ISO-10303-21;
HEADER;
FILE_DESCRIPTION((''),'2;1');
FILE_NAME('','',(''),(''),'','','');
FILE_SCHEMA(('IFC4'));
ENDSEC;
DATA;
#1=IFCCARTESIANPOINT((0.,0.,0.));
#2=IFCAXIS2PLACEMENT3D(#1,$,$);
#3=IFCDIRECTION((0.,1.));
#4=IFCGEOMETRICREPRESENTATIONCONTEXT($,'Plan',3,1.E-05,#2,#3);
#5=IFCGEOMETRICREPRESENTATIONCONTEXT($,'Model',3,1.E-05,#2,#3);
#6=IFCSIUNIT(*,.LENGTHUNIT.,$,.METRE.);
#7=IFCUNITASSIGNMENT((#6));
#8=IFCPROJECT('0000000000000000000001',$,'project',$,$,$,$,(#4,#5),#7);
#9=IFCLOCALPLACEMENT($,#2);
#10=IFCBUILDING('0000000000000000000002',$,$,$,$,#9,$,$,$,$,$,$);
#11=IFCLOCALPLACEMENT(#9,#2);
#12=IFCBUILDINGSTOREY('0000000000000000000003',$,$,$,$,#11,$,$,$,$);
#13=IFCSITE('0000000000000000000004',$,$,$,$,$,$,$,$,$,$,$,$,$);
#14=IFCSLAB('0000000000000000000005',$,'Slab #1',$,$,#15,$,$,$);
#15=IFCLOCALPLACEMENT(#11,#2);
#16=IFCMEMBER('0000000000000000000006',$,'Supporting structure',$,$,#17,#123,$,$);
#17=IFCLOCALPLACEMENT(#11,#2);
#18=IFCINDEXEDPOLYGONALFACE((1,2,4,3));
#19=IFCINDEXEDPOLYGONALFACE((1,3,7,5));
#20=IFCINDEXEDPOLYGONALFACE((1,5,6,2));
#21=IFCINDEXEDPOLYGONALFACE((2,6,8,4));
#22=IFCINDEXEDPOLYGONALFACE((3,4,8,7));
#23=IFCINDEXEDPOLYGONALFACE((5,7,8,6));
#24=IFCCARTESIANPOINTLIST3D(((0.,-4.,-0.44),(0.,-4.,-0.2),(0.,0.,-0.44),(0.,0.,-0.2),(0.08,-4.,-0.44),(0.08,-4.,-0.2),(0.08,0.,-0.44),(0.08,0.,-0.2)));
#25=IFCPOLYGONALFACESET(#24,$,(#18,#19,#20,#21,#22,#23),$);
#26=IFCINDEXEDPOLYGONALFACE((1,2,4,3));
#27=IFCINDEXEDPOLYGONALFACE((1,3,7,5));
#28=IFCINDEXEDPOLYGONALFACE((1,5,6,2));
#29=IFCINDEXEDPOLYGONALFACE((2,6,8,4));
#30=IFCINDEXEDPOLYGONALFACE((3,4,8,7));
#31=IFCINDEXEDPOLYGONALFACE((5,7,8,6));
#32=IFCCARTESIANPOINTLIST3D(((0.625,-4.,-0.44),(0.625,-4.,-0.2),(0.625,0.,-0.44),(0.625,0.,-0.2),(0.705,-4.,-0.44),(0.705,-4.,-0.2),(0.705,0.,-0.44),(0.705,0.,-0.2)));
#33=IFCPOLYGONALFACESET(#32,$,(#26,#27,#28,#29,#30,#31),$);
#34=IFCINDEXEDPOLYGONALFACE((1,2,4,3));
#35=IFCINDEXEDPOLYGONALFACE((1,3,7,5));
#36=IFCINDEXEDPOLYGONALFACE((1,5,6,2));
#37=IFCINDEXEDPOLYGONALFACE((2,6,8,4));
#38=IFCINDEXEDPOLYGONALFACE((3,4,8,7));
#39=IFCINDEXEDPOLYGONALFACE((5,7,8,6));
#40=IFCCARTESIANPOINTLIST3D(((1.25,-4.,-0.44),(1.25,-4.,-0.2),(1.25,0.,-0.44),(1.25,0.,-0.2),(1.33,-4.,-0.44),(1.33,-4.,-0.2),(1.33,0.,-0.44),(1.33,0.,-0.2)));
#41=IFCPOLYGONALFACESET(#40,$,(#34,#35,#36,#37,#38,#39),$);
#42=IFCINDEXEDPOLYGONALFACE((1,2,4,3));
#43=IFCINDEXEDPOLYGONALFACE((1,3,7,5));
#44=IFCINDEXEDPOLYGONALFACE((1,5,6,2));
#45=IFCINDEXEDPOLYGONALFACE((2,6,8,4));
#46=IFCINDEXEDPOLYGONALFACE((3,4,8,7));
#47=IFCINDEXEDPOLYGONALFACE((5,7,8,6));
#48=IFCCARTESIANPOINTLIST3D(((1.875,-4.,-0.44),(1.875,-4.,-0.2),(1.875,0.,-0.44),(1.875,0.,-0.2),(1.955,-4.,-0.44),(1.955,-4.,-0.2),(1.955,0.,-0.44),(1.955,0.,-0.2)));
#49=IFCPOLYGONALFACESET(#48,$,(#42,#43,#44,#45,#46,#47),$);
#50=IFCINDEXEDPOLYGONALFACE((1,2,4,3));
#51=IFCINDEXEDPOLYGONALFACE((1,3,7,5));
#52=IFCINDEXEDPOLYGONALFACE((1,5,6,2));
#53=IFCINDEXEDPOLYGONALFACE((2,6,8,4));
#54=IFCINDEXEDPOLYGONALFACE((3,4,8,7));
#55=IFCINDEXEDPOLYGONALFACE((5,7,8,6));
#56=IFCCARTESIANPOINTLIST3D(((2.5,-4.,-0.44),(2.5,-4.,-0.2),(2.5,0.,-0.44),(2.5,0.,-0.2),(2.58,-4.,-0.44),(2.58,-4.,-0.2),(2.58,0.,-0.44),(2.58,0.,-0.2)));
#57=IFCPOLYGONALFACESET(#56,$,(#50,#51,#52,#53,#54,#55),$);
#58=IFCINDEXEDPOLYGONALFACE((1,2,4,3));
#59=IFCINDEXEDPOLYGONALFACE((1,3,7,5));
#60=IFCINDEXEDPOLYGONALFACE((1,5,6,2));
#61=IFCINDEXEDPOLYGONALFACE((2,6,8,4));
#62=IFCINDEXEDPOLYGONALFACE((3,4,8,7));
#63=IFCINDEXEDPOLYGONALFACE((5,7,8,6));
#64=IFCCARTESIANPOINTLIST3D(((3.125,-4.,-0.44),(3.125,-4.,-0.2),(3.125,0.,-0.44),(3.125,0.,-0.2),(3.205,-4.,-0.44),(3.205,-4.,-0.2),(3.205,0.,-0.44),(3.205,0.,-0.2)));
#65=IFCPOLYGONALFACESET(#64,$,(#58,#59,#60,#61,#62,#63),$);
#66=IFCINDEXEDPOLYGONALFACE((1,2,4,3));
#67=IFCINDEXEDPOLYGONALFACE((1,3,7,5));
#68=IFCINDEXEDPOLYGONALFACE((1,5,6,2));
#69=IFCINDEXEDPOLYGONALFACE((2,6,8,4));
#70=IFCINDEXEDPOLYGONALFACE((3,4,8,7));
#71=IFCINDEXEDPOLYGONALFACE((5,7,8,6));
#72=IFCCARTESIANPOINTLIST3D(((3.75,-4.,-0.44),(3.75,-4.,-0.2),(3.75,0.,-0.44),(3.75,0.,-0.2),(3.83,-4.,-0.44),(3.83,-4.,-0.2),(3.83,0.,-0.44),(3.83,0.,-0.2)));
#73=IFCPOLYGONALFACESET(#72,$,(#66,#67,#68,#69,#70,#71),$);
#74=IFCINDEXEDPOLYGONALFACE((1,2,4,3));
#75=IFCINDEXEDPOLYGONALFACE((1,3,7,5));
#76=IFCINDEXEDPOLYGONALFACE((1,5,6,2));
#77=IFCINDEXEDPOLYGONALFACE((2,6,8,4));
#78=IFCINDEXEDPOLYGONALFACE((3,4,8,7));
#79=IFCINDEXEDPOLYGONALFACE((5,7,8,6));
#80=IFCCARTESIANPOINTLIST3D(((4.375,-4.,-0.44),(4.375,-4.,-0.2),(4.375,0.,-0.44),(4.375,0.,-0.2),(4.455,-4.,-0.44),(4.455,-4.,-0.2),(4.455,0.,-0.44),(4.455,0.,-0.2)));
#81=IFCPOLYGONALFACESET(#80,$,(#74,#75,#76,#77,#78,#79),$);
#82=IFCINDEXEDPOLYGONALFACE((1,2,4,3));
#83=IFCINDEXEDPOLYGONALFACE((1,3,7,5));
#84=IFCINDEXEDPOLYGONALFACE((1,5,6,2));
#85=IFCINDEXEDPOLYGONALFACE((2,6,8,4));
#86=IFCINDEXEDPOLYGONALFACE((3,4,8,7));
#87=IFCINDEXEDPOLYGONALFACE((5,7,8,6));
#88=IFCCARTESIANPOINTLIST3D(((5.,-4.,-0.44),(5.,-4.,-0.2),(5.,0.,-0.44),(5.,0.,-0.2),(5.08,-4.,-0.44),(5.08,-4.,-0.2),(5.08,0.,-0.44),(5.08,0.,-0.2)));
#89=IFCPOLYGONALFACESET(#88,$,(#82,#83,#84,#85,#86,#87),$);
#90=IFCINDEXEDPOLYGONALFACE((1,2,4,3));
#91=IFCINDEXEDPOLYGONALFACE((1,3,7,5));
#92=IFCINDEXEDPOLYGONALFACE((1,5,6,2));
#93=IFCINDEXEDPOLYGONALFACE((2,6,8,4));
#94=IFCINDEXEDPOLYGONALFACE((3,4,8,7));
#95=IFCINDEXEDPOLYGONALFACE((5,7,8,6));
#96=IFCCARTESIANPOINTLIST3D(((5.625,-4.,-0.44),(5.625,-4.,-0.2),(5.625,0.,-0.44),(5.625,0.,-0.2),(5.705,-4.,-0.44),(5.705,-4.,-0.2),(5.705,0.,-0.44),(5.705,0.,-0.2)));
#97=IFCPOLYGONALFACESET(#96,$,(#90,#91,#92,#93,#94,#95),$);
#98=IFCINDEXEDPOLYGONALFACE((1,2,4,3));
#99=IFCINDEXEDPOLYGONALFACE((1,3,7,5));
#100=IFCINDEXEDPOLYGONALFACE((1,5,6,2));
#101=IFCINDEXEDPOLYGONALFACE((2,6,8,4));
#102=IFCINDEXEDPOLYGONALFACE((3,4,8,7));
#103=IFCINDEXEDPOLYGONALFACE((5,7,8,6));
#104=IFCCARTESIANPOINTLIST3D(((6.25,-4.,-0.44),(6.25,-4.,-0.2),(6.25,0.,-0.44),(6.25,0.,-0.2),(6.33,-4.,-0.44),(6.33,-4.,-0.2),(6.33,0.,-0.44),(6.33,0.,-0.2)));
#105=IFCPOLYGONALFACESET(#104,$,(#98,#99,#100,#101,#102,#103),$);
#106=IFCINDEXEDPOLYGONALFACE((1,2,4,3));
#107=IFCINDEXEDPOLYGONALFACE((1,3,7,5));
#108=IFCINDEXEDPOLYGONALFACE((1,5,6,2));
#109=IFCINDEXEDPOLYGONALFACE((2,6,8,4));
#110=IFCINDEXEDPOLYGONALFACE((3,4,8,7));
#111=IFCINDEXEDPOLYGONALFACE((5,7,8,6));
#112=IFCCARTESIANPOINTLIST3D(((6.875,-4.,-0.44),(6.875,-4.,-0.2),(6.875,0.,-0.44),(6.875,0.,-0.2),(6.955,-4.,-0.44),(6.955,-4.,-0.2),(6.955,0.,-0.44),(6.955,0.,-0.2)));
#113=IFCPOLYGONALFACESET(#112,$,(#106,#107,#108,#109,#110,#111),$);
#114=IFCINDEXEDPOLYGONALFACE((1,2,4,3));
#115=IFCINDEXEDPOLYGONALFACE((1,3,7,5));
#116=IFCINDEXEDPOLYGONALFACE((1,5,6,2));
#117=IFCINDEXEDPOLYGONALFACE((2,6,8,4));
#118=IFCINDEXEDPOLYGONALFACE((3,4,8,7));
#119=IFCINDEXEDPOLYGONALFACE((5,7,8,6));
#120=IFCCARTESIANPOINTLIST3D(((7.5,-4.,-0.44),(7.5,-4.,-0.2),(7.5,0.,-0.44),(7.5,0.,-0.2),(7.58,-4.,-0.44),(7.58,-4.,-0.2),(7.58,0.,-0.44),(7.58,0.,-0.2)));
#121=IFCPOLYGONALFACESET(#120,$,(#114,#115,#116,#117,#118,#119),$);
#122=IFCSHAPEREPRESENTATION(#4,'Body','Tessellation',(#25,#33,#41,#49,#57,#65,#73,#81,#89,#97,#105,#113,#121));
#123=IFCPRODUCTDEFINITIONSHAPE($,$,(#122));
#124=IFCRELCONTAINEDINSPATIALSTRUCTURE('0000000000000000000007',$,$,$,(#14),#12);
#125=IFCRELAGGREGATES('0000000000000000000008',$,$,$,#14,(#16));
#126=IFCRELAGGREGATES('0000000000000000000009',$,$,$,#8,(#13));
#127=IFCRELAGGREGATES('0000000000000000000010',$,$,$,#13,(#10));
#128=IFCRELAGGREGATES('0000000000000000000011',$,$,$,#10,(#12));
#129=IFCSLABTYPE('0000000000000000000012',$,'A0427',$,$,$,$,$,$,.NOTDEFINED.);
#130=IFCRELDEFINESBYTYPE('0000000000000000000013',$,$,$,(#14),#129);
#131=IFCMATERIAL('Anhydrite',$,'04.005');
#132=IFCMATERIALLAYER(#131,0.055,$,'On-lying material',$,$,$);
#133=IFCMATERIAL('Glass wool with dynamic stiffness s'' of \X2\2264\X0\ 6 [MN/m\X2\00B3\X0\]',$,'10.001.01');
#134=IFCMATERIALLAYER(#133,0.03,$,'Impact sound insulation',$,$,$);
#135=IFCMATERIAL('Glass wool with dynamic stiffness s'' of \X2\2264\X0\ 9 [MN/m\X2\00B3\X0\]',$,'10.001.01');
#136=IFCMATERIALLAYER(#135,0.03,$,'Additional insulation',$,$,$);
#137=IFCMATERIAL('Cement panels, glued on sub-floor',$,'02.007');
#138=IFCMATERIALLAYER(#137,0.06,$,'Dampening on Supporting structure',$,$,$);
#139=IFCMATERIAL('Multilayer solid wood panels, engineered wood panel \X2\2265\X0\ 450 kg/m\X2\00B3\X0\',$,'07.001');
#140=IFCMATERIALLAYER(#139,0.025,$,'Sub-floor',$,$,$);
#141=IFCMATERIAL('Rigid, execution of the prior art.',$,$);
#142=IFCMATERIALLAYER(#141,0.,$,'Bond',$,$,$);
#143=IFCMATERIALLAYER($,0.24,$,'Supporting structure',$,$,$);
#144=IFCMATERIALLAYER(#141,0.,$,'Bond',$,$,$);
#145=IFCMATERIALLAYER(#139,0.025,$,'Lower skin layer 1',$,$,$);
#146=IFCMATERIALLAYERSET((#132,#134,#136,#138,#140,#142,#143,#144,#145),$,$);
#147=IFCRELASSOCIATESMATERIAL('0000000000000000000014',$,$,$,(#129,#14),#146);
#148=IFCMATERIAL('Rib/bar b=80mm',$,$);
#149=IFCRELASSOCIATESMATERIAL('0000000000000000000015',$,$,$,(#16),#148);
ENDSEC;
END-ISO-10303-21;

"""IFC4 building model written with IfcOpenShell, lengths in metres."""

from ifc_helpers import new_model, si_unit, direction, frame, frame_2d, origin, place, context, project, spatial, rectangle, extrude, material, layer, layer_set, type_object, element, aggregate, save


model = new_model("IFC4")

# Units and contexts
plan_context = context("Plan", 3, precision=1e-05, world=origin(), true_north=direction((0.0, 1.0)))
model_context = context("Model", 3, precision=1e-05, world=origin(), true_north=direction((0.0, 1.0)))
ifc_project = project(units=[si_unit("LENGTHUNIT", "METRE")], contexts=[plan_context, model_context])

# Site, building, storey
site = spatial("IfcSite", under=ifc_project)
building_placement = place(None, origin())
building = spatial("IfcBuilding", under=site, at=building_placement)
storey_placement = place(building_placement, origin())
storey = spatial("IfcBuildingStorey", under=building, at=storey_placement)

# Slab, member
ifc_material_1 = material(Name="Anhydrite", Category="04.005")
ifc_layer_1 = layer(ifc_material_1, 0.055, Name="On-lying material")
ifc_material_2 = material(Name="Glass wool with dynamic stiffness s' of ≤ 6 [MN/m³]", Category="10.001.01")
ifc_layer_2 = layer(ifc_material_2, 0.03, Name="Impact sound insulation")
ifc_material_3 = material(Name="Glass wool with dynamic stiffness s' of ≤ 9 [MN/m³]", Category="10.001.01")
ifc_layer_3 = layer(ifc_material_3, 0.03, Name="Additional insulation")
ifc_material_4 = material(Name="Cement panels, glued on sub-floor", Category="02.007")
ifc_layer_4 = layer(ifc_material_4, 0.06, Name="Dampening on Supporting structure")
ifc_material_5 = material(Name="Multilayer solid wood panels, engineered wood panel ≥ 450 kg/m³", Category="07.001")
ifc_layer_5 = layer(ifc_material_5, 0.025, Name="Sub-floor")
ifc_material_6 = material(Name="Rigid, execution of the prior art.")
ifc_layer_6 = layer(ifc_material_6, 0.0, Name="Bond")
ifc_layer_7 = layer(None, 0.24, Name="Supporting structure")
ifc_layer_8 = layer(ifc_material_6, 0.0, Name="Bond")
ifc_layer_9 = layer(ifc_material_5, 0.025, Name="Lower skin layer 1")
ifc_layer_set = layer_set([ifc_layer_1, ifc_layer_2, ifc_layer_3, ifc_layer_4, ifc_layer_5, ifc_layer_6, ifc_layer_7, ifc_layer_8, ifc_layer_9])
slab_type = type_object("IfcSlabType", Name="A0427", PredefinedType="NOTDEFINED", material=ifc_layer_set)
slab_placement = place(None, frame((0.0, 0.0, 0.0), z_axis=(0.0, 0.0, -1.0), x_axis=(1.0, 0.0, 0.0)))
slab = element("IfcSlab", 1, at=slab_placement, inside=storey, type_object=slab_type, material=ifc_layer_set, Name="Slab #1")
ifc_material_7 = material(Name="Rib/bar b=80mm")
member_1_placement = place(slab_placement, origin())
member_1 = element("IfcMember", 2, at=member_1_placement, material=ifc_material_7, Name="Supporting structure", context=plan_context, shape_type="SweptSolid", body=[
    extrude(rectangle(XDim=0.08, YDim=0.24, at=frame_2d((0.04, 0.12), x_axis=(1.0, 0.0))), frame((0.0, 4.0, 0.2), z_axis=(0.0, -1.0, 0.0), x_axis=(1.0, 0.0, 0.0)), (0.0, 0.0, 1.0), 4.0),
    extrude(rectangle(XDim=0.08, YDim=0.24, at=frame_2d((0.04, 0.12), x_axis=(1.0, 0.0))), frame((0.625, 4.0, 0.2), z_axis=(0.0, -1.0, 0.0), x_axis=(1.0, 0.0, 0.0)), (0.0, 0.0, 1.0), 4.0),
    extrude(rectangle(XDim=0.08, YDim=0.24, at=frame_2d((0.04, 0.12), x_axis=(1.0, 0.0))), frame((1.25, 4.0, 0.2), z_axis=(0.0, -1.0, 0.0), x_axis=(1.0, 0.0, 0.0)), (0.0, 0.0, 1.0), 4.0),
    extrude(rectangle(XDim=0.08, YDim=0.24, at=frame_2d((0.04, 0.12), x_axis=(1.0, 0.0))), frame((1.875, 4.0, 0.2), z_axis=(0.0, -1.0, 0.0), x_axis=(1.0, 0.0, 0.0)), (0.0, 0.0, 1.0), 4.0),
    extrude(rectangle(XDim=0.08, YDim=0.24, at=frame_2d((0.04, 0.12), x_axis=(1.0, 0.0))), frame((2.5, 4.0, 0.2), z_axis=(0.0, -1.0, 0.0), x_axis=(1.0, 0.0, 0.0)), (0.0, 0.0, 1.0), 4.0),
    extrude(rectangle(XDim=0.08, YDim=0.24, at=frame_2d((0.04, 0.12), x_axis=(1.0, 0.0))), frame((3.125, 4.0, 0.2), z_axis=(0.0, -1.0, 0.0), x_axis=(1.0, 0.0, 0.0)), (0.0, 0.0, 1.0), 4.0),
    extrude(rectangle(XDim=0.08, YDim=0.24, at=frame_2d((0.04, 0.12), x_axis=(1.0, 0.0))), frame((3.75, 4.0, 0.2), z_axis=(0.0, -1.0, 0.0), x_axis=(1.0, 0.0, 0.0)), (0.0, 0.0, 1.0), 4.0),
    extrude(rectangle(XDim=0.08, YDim=0.24, at=frame_2d((0.04, 0.12), x_axis=(1.0, 0.0))), frame((4.375, 4.0, 0.2), z_axis=(0.0, -1.0, 0.0), x_axis=(1.0, 0.0, 0.0)), (0.0, 0.0, 1.0), 4.0),
    extrude(rectangle(XDim=0.08, YDim=0.24, at=frame_2d((0.04, 0.12), x_axis=(1.0, 0.0))), frame((5.0, 4.0, 0.2), z_axis=(0.0, -1.0, 0.0), x_axis=(1.0, 0.0, 0.0)), (0.0, 0.0, 1.0), 4.0),
    extrude(rectangle(XDim=0.08, YDim=0.24, at=frame_2d((0.04, 0.12), x_axis=(1.0, 0.0))), frame((5.625, 4.0, 0.2), z_axis=(0.0, -1.0, 0.0), x_axis=(1.0, 0.0, 0.0)), (0.0, 0.0, 1.0), 4.0),
    extrude(rectangle(XDim=0.08, YDim=0.24, at=frame_2d((0.04, 0.12), x_axis=(1.0, 0.0))), frame((6.25, 4.0, 0.2), z_axis=(0.0, -1.0, 0.0), x_axis=(1.0, 0.0, 0.0)), (0.0, 0.0, 1.0), 4.0),
    extrude(rectangle(XDim=0.08, YDim=0.24, at=frame_2d((0.04, 0.12), x_axis=(1.0, 0.0))), frame((6.875, 4.0, 0.2), z_axis=(0.0, -1.0, 0.0), x_axis=(1.0, 0.0, 0.0)), (0.0, 0.0, 1.0), 4.0),
    extrude(rectangle(XDim=0.08, YDim=0.24, at=frame_2d((0.04, 0.12), x_axis=(1.0, 0.0))), frame((7.5, 4.0, 0.2), z_axis=(0.0, -1.0, 0.0), x_axis=(1.0, 0.0, 0.0)), (0.0, 0.0, 1.0), 4.0),
])
aggregate(slab, [member_1])

save(model, "model.ifc")
